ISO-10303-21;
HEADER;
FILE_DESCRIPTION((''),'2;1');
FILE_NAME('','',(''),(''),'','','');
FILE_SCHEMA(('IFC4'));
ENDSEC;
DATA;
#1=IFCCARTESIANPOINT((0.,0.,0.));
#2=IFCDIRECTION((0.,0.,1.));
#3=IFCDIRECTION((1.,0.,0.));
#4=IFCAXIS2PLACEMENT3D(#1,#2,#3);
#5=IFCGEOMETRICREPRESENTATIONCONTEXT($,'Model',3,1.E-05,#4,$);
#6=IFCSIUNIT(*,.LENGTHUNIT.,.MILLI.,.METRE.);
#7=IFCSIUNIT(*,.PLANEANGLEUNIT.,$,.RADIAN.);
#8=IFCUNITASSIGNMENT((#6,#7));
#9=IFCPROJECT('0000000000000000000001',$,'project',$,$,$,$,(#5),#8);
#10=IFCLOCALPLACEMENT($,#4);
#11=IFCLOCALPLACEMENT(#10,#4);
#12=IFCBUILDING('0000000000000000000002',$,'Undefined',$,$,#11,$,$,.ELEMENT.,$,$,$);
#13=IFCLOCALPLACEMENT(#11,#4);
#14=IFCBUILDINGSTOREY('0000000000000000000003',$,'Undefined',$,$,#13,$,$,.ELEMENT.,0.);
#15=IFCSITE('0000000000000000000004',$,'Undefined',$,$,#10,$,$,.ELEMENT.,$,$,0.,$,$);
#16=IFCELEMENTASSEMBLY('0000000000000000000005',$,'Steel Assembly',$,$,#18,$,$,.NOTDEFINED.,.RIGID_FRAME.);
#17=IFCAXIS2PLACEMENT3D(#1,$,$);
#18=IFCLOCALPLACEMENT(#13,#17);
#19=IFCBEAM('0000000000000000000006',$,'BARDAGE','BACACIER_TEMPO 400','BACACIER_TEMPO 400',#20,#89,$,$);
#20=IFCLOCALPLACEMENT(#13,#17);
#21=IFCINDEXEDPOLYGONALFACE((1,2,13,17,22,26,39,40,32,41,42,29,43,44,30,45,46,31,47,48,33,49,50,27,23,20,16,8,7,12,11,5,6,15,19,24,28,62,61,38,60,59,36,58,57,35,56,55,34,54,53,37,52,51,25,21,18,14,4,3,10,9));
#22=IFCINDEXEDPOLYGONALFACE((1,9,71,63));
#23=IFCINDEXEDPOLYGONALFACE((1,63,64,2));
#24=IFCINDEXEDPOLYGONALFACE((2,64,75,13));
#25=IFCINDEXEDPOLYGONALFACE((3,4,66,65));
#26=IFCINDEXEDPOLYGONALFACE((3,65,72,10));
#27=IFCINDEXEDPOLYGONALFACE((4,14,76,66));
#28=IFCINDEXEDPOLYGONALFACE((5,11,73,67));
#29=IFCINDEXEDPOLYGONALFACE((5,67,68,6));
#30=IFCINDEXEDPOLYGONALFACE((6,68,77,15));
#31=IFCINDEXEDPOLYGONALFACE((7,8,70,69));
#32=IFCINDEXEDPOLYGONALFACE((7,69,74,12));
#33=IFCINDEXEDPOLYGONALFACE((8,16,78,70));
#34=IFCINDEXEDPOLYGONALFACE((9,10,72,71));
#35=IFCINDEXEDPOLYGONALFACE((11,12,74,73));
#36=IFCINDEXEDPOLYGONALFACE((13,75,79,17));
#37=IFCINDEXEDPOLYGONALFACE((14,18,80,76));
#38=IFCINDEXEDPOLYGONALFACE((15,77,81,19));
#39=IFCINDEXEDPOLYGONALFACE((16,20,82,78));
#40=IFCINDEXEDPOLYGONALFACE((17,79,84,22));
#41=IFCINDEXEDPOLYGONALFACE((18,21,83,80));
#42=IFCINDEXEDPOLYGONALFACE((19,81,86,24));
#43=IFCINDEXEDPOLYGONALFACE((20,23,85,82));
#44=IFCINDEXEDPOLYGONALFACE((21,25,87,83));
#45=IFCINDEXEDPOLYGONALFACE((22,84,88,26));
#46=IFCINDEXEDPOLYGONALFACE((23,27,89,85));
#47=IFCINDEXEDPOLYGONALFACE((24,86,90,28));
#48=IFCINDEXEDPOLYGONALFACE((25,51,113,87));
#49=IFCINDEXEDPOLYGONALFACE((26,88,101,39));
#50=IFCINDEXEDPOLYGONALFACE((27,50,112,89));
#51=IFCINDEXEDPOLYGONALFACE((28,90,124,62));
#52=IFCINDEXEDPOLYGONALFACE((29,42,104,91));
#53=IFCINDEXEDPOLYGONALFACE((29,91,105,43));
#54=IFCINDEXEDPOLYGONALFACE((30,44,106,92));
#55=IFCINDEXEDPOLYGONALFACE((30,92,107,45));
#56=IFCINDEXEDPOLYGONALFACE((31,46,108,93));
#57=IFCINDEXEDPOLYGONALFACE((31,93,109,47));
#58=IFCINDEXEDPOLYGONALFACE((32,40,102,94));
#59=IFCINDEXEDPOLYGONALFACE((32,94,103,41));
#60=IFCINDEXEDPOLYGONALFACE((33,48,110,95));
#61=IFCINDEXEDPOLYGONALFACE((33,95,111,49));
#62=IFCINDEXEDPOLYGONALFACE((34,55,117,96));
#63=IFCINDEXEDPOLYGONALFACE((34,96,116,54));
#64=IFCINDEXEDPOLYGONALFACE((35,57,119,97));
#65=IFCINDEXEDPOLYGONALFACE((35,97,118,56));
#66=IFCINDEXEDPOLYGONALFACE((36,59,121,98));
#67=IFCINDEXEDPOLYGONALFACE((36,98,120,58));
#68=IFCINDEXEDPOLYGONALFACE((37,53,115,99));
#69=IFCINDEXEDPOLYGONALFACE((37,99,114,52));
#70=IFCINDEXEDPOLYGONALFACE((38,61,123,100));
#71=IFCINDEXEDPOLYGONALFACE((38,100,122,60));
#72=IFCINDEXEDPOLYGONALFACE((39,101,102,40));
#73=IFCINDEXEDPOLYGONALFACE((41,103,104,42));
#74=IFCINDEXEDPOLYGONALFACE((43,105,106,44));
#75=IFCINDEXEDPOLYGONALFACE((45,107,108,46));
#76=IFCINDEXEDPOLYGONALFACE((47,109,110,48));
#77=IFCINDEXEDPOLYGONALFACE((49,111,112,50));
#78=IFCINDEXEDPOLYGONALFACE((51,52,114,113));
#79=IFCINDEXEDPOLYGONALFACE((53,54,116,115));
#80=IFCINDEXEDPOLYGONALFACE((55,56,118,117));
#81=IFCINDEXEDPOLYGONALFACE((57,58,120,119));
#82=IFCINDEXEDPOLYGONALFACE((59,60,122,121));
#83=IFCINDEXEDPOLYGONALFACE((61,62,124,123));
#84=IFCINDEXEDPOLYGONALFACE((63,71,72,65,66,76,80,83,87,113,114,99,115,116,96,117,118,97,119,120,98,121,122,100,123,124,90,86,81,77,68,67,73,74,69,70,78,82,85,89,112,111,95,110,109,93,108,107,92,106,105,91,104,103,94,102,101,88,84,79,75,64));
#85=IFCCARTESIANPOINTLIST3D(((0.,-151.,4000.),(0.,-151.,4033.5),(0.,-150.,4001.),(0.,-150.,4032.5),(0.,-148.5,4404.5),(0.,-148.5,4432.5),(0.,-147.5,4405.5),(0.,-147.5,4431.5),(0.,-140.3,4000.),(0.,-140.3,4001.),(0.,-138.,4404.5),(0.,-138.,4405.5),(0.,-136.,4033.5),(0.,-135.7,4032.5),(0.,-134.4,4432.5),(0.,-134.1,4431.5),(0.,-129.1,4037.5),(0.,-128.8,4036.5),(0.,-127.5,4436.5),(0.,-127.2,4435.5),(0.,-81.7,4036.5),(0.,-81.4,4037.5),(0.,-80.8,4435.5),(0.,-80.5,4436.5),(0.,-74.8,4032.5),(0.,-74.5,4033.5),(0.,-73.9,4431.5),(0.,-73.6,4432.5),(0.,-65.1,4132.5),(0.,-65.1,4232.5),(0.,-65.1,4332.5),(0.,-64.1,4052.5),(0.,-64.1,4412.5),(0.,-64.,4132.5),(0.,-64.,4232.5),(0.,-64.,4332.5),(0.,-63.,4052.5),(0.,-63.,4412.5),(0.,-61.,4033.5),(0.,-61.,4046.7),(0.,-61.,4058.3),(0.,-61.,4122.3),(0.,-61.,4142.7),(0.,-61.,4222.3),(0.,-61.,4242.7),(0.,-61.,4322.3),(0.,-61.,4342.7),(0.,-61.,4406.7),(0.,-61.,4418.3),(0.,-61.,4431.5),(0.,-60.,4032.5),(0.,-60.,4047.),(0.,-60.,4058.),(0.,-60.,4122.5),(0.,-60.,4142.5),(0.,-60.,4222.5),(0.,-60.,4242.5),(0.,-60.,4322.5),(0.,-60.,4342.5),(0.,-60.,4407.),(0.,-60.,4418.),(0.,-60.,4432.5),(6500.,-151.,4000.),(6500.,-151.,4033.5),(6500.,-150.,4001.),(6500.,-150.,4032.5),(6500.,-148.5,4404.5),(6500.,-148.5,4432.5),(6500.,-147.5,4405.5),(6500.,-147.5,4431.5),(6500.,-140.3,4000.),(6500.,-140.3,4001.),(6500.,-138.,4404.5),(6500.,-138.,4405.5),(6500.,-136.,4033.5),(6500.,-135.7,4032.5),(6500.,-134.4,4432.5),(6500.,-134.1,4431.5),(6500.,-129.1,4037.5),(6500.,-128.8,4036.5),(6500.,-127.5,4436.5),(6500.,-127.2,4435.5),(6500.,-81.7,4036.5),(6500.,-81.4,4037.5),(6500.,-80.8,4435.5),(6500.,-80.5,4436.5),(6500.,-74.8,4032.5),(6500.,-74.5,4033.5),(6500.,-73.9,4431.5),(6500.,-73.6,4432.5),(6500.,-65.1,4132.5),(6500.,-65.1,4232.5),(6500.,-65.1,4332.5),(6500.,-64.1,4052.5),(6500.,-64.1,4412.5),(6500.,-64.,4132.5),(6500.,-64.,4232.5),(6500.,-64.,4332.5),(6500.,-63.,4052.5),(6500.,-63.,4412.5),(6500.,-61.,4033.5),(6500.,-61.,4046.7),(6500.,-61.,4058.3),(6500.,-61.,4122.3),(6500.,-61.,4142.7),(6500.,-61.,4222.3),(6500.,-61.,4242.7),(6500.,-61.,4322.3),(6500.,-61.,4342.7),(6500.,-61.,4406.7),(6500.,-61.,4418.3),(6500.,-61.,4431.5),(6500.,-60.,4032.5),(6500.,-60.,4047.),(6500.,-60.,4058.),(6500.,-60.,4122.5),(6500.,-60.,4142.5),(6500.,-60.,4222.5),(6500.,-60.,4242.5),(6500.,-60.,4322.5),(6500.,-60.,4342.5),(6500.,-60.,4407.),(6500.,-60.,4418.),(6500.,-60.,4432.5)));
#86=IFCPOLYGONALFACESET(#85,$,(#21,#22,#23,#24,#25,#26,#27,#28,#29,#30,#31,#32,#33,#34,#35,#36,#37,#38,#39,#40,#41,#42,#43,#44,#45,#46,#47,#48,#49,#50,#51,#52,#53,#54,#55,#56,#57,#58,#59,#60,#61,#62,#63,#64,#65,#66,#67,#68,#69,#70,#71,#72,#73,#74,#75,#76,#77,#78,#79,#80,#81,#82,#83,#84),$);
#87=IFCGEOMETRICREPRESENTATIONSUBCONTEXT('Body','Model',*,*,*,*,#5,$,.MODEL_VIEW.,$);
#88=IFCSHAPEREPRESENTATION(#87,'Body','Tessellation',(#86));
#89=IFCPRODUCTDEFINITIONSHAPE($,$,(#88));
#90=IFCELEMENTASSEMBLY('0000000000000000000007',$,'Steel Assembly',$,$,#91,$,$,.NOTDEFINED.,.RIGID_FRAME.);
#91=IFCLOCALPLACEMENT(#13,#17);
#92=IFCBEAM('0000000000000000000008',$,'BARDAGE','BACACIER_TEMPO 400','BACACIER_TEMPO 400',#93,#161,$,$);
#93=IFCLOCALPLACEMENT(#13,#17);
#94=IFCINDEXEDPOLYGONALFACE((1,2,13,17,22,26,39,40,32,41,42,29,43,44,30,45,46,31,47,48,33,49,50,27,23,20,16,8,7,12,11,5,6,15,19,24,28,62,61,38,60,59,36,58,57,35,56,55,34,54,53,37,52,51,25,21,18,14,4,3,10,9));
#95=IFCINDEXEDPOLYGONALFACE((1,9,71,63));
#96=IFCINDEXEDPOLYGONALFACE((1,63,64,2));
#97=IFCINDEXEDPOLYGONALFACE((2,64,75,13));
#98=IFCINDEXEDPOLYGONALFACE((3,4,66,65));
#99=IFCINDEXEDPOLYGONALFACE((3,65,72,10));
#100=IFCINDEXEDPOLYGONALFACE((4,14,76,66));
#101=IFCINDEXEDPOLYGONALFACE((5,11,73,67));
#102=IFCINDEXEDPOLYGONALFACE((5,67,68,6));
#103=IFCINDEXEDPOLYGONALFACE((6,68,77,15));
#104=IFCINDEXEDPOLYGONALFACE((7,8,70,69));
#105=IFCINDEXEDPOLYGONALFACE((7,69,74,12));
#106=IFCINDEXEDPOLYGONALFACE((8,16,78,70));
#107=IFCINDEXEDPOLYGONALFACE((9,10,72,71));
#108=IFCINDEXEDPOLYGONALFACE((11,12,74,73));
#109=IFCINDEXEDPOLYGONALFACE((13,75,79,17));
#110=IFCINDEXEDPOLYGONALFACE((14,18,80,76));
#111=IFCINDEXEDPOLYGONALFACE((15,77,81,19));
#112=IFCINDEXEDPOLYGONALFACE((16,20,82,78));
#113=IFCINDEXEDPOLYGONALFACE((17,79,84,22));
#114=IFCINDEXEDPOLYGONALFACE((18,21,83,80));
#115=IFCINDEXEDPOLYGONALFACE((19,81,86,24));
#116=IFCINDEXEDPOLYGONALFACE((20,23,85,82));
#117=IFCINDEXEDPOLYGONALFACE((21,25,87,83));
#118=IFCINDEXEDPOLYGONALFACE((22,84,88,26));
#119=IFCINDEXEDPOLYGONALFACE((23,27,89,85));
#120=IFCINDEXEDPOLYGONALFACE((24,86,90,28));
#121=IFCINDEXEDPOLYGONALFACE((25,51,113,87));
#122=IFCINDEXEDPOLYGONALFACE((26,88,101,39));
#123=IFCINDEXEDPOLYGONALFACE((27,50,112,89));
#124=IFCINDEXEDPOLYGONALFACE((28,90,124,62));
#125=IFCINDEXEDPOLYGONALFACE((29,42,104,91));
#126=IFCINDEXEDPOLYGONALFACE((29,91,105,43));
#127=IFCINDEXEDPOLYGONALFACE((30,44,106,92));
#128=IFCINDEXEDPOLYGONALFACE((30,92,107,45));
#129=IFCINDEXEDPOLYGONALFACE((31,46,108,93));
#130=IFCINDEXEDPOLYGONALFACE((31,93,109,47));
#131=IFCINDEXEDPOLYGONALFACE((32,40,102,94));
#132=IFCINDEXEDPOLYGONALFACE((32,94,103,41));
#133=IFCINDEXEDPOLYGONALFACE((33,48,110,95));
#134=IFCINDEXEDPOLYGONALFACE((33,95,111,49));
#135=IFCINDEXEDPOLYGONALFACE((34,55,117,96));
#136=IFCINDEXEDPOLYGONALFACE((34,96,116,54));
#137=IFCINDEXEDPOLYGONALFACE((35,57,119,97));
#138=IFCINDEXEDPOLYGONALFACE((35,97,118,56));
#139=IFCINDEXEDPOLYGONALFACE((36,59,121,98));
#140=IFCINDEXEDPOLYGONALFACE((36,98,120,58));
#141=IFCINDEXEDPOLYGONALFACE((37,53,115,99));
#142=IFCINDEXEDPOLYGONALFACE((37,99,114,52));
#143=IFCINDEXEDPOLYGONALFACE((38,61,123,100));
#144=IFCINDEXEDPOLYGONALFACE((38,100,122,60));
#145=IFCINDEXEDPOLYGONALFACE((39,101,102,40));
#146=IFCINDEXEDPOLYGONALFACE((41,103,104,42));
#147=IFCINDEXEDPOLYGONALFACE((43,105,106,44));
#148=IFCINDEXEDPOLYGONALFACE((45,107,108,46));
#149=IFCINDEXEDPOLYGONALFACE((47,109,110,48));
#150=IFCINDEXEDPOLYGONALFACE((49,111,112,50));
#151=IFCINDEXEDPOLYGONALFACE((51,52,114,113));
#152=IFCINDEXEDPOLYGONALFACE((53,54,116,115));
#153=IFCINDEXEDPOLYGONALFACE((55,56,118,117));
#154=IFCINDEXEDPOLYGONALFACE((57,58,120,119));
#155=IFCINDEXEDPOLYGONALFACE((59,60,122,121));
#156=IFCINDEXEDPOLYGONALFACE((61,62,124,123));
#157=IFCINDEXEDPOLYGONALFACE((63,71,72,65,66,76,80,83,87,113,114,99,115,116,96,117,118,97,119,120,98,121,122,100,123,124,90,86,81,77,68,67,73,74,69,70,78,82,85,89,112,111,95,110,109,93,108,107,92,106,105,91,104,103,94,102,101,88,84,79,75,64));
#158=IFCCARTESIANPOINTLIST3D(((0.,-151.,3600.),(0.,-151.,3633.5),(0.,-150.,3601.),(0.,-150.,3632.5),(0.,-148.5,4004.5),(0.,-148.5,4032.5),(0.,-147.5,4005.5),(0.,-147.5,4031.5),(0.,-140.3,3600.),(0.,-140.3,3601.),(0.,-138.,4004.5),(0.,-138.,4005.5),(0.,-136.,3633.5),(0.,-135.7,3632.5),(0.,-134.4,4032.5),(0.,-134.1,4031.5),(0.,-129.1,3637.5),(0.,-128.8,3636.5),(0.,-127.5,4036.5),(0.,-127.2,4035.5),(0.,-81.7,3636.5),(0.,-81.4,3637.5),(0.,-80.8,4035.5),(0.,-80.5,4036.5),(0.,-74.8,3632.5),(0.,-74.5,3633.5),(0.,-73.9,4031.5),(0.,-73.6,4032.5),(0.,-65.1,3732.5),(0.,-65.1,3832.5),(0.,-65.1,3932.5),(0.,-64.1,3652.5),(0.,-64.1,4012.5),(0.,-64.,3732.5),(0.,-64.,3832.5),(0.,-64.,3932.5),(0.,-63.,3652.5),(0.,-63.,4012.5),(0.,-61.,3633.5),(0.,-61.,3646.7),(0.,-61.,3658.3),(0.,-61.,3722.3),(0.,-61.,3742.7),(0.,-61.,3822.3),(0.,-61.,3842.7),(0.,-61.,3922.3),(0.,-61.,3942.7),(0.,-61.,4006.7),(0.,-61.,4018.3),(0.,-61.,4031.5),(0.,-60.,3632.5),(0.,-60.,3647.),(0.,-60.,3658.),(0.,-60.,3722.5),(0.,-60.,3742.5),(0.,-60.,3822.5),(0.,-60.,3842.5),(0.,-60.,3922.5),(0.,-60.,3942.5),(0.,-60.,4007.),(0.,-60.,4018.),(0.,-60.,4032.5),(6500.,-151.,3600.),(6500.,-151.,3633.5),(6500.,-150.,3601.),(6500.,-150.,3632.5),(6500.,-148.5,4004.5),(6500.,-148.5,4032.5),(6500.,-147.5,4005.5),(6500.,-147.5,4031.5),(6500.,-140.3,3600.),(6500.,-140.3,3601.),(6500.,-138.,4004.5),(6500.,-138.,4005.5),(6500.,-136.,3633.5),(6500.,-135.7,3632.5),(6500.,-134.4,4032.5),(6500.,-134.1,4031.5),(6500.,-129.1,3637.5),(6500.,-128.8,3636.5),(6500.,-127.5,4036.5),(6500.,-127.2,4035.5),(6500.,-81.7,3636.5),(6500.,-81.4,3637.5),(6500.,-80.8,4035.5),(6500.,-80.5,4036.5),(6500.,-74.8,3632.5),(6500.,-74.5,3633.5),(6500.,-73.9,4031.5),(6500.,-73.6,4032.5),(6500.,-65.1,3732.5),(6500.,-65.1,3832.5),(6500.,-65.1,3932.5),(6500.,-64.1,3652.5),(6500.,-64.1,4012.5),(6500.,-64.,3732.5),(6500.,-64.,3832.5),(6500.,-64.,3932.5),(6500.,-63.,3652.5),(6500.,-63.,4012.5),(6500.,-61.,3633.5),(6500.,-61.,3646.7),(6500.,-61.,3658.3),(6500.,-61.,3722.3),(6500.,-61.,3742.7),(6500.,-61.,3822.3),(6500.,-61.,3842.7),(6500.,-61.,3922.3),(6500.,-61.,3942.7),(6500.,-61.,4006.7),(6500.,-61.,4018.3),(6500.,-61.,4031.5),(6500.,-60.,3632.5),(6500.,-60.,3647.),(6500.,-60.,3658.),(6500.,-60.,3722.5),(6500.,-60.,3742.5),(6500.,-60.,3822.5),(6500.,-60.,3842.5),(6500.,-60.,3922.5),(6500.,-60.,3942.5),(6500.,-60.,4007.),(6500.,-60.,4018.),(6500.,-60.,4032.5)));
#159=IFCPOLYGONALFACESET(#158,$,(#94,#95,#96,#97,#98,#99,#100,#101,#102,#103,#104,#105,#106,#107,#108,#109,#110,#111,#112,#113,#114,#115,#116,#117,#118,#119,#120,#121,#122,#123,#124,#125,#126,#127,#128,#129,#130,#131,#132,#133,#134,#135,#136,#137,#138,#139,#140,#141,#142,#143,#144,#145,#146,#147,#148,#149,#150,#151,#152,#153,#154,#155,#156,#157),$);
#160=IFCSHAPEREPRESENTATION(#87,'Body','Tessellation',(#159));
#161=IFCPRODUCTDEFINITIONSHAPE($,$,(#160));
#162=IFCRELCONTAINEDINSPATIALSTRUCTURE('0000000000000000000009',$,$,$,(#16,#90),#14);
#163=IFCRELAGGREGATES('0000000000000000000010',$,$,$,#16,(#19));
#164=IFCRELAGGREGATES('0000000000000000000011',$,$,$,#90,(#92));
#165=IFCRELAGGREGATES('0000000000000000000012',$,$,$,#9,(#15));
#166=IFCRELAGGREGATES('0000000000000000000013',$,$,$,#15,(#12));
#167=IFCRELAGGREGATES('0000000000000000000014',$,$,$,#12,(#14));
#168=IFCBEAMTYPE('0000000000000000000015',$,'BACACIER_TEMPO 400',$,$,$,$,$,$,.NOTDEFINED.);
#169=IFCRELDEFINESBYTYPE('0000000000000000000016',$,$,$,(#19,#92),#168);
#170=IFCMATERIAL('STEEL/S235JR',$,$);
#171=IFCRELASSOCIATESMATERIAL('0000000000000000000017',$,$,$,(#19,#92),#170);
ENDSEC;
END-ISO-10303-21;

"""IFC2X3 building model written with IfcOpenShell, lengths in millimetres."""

from ifc_helpers import new_model, si_unit, frame, origin_with_axes, place, context, subcontext, project, spatial, polyline, outline, extrude, material, type_object, element, aggregate, save


model = new_model("IFC2X3")

# Units and contexts
model_context = context("Model", 3, precision=1e-05, world=origin_with_axes())
body_context = subcontext(model_context, "Body", "Model", "MODEL_VIEW")
ifc_project = project(units=[si_unit("LENGTHUNIT", "METRE", prefix="MILLI"), si_unit("PLANEANGLEUNIT", "RADIAN")], contexts=[model_context])

# Site, building, storey
site_placement = place(None, origin_with_axes())
site = spatial("IfcSite", under=ifc_project, at=site_placement, Name="Undefined", CompositionType="ELEMENT", RefElevation=0.0)
building_placement = place(site_placement, origin_with_axes())
building = spatial("IfcBuilding", under=site, at=building_placement, Name="Undefined", CompositionType="ELEMENT")
storey_placement = place(building_placement, origin_with_axes())
storey = spatial("IfcBuildingStorey", under=building, at=storey_placement, Name="Undefined", CompositionType="ELEMENT", Elevation=0.0)

# Element assemblies, beams
ifc_material_1 = material(Name="STEEL/S235JR")
beam_type_1 = type_object("IfcBeamType", Name="BACACIER_TEMPO 400", PredefinedType="NOTDEFINED")
assembly_1_placement = place(storey_placement, origin_with_axes())
assembly_1 = element("IfcElementAssembly", 1, at=assembly_1_placement, inside=storey, Name="Steel Assembly", AssemblyPlace="NOTDEFINED", PredefinedType="RIGID_FRAME")
beam_1_placement = place(assembly_1_placement, frame((6500.0, -105.5, 4218.2), z_axis=(0.0, -1.0, 0.0), x_axis=(-1.0, 0.0, 0.0)))
beam_1 = element("IfcBeam", 2, at=beam_1_placement, type_object=beam_type_1, material=ifc_material_1, Name="BARDAGE", Description="BACACIER_TEMPO 400", ObjectType="BACACIER_TEMPO 400", context=body_context, shape_type="SweptSolid", body=[
    extrude(outline(polyline([(218.2, -25.0), (214.2, -31.9), (214.2, -45.5), (199.8, -45.5), (194.2, -42.5), (188.8, -45.5), (124.2, -45.5), (114.2, -41.5), (104.2, -45.5), (24.2, -45.5), (14.2, -41.5), (4.2, -45.5), (-75.8, -45.5), (-85.8, -41.5), (-95.8, -45.5), (-160.2, -45.5), (-165.8, -42.5), (-171.2, -45.5), (-185.8, -45.5), (-185.8, -30.7), (-181.8, -23.8), (-181.8, 23.3), (-185.8, 30.2), (-185.8, 44.5), (-217.2, 44.5), (-217.2, 34.8), (-218.2, 34.8), (-218.2, 45.5), (-184.8, 45.5), (-184.8, 30.5), (-180.8, 23.6), (-180.8, -24.1), (-184.8, -31.0), (-184.8, -44.5), (-171.5, -44.5), (-165.8, -41.4), (-160.0, -44.5), (-95.9, -44.5), (-85.8, -40.4), (-75.6, -44.5), (4.1, -44.5), (14.2, -40.4), (24.4, -44.5), (104.1, -44.5), (114.2, -40.4), (124.4, -44.5), (188.5, -44.5), (194.2, -41.4), (200.0, -44.5), (213.2, -44.5), (213.2, -31.6), (217.2, -24.7), (217.2, 21.7), (213.2, 28.6), (213.2, 42.0), (187.2, 42.0), (187.2, 32.5), (186.2, 32.5), (186.2, 43.0), (214.2, 43.0), (214.2, 28.9), (218.2, 22.0), (218.2, -25.0)])), frame((6500.0, 0.0, 0.0), z_axis=(-1.0, 0.0, 0.0), x_axis=(0.0, -1.0, 0.0)), (0.0, 0.0, 1.0), 6500.0),
])
aggregate(assembly_1, [beam_1])
assembly_2_placement = place(storey_placement, origin_with_axes())
assembly_2 = element("IfcElementAssembly", 3, at=assembly_2_placement, inside=storey, Name="Steel Assembly", AssemblyPlace="NOTDEFINED", PredefinedType="RIGID_FRAME")
beam_2_placement = place(assembly_2_placement, frame((6500.0, -105.5, 3818.2), z_axis=(0.0, -1.0, 0.0), x_axis=(-1.0, 0.0, 0.0)))
beam_2 = element("IfcBeam", 4, at=beam_2_placement, type_object=beam_type_1, material=ifc_material_1, Name="BARDAGE", Description="BACACIER_TEMPO 400", ObjectType="BACACIER_TEMPO 400", context=body_context, shape_type="SweptSolid", body=[
    extrude(outline(polyline([(218.2, -25.0), (214.2, -31.9), (214.2, -45.5), (199.8, -45.5), (194.2, -42.5), (188.8, -45.5), (124.2, -45.5), (114.2, -41.5), (104.2, -45.5), (24.2, -45.5), (14.2, -41.5), (4.2, -45.5), (-75.8, -45.5), (-85.8, -41.5), (-95.8, -45.5), (-160.2, -45.5), (-165.8, -42.5), (-171.2, -45.5), (-185.8, -45.5), (-185.8, -30.7), (-181.8, -23.8), (-181.8, 23.3), (-185.8, 30.2), (-185.8, 44.5), (-217.2, 44.5), (-217.2, 34.8), (-218.2, 34.8), (-218.2, 45.5), (-184.8, 45.5), (-184.8, 30.5), (-180.8, 23.6), (-180.8, -24.1), (-184.8, -31.0), (-184.8, -44.5), (-171.5, -44.5), (-165.8, -41.4), (-160.0, -44.5), (-95.9, -44.5), (-85.8, -40.4), (-75.6, -44.5), (4.1, -44.5), (14.2, -40.4), (24.4, -44.5), (104.1, -44.5), (114.2, -40.4), (124.4, -44.5), (188.5, -44.5), (194.2, -41.4), (200.0, -44.5), (213.2, -44.5), (213.2, -31.6), (217.2, -24.7), (217.2, 21.7), (213.2, 28.6), (213.2, 42.0), (187.2, 42.0), (187.2, 32.5), (186.2, 32.5), (186.2, 43.0), (214.2, 43.0), (214.2, 28.9), (218.2, 22.0), (218.2, -25.0)])), frame((6500.0, 0.0, 0.0), z_axis=(-1.0, 0.0, 0.0), x_axis=(0.0, -1.0, 0.0)), (0.0, 0.0, 1.0), 6500.0),
])
aggregate(assembly_2, [beam_2])

save(model, "model.ifc")
